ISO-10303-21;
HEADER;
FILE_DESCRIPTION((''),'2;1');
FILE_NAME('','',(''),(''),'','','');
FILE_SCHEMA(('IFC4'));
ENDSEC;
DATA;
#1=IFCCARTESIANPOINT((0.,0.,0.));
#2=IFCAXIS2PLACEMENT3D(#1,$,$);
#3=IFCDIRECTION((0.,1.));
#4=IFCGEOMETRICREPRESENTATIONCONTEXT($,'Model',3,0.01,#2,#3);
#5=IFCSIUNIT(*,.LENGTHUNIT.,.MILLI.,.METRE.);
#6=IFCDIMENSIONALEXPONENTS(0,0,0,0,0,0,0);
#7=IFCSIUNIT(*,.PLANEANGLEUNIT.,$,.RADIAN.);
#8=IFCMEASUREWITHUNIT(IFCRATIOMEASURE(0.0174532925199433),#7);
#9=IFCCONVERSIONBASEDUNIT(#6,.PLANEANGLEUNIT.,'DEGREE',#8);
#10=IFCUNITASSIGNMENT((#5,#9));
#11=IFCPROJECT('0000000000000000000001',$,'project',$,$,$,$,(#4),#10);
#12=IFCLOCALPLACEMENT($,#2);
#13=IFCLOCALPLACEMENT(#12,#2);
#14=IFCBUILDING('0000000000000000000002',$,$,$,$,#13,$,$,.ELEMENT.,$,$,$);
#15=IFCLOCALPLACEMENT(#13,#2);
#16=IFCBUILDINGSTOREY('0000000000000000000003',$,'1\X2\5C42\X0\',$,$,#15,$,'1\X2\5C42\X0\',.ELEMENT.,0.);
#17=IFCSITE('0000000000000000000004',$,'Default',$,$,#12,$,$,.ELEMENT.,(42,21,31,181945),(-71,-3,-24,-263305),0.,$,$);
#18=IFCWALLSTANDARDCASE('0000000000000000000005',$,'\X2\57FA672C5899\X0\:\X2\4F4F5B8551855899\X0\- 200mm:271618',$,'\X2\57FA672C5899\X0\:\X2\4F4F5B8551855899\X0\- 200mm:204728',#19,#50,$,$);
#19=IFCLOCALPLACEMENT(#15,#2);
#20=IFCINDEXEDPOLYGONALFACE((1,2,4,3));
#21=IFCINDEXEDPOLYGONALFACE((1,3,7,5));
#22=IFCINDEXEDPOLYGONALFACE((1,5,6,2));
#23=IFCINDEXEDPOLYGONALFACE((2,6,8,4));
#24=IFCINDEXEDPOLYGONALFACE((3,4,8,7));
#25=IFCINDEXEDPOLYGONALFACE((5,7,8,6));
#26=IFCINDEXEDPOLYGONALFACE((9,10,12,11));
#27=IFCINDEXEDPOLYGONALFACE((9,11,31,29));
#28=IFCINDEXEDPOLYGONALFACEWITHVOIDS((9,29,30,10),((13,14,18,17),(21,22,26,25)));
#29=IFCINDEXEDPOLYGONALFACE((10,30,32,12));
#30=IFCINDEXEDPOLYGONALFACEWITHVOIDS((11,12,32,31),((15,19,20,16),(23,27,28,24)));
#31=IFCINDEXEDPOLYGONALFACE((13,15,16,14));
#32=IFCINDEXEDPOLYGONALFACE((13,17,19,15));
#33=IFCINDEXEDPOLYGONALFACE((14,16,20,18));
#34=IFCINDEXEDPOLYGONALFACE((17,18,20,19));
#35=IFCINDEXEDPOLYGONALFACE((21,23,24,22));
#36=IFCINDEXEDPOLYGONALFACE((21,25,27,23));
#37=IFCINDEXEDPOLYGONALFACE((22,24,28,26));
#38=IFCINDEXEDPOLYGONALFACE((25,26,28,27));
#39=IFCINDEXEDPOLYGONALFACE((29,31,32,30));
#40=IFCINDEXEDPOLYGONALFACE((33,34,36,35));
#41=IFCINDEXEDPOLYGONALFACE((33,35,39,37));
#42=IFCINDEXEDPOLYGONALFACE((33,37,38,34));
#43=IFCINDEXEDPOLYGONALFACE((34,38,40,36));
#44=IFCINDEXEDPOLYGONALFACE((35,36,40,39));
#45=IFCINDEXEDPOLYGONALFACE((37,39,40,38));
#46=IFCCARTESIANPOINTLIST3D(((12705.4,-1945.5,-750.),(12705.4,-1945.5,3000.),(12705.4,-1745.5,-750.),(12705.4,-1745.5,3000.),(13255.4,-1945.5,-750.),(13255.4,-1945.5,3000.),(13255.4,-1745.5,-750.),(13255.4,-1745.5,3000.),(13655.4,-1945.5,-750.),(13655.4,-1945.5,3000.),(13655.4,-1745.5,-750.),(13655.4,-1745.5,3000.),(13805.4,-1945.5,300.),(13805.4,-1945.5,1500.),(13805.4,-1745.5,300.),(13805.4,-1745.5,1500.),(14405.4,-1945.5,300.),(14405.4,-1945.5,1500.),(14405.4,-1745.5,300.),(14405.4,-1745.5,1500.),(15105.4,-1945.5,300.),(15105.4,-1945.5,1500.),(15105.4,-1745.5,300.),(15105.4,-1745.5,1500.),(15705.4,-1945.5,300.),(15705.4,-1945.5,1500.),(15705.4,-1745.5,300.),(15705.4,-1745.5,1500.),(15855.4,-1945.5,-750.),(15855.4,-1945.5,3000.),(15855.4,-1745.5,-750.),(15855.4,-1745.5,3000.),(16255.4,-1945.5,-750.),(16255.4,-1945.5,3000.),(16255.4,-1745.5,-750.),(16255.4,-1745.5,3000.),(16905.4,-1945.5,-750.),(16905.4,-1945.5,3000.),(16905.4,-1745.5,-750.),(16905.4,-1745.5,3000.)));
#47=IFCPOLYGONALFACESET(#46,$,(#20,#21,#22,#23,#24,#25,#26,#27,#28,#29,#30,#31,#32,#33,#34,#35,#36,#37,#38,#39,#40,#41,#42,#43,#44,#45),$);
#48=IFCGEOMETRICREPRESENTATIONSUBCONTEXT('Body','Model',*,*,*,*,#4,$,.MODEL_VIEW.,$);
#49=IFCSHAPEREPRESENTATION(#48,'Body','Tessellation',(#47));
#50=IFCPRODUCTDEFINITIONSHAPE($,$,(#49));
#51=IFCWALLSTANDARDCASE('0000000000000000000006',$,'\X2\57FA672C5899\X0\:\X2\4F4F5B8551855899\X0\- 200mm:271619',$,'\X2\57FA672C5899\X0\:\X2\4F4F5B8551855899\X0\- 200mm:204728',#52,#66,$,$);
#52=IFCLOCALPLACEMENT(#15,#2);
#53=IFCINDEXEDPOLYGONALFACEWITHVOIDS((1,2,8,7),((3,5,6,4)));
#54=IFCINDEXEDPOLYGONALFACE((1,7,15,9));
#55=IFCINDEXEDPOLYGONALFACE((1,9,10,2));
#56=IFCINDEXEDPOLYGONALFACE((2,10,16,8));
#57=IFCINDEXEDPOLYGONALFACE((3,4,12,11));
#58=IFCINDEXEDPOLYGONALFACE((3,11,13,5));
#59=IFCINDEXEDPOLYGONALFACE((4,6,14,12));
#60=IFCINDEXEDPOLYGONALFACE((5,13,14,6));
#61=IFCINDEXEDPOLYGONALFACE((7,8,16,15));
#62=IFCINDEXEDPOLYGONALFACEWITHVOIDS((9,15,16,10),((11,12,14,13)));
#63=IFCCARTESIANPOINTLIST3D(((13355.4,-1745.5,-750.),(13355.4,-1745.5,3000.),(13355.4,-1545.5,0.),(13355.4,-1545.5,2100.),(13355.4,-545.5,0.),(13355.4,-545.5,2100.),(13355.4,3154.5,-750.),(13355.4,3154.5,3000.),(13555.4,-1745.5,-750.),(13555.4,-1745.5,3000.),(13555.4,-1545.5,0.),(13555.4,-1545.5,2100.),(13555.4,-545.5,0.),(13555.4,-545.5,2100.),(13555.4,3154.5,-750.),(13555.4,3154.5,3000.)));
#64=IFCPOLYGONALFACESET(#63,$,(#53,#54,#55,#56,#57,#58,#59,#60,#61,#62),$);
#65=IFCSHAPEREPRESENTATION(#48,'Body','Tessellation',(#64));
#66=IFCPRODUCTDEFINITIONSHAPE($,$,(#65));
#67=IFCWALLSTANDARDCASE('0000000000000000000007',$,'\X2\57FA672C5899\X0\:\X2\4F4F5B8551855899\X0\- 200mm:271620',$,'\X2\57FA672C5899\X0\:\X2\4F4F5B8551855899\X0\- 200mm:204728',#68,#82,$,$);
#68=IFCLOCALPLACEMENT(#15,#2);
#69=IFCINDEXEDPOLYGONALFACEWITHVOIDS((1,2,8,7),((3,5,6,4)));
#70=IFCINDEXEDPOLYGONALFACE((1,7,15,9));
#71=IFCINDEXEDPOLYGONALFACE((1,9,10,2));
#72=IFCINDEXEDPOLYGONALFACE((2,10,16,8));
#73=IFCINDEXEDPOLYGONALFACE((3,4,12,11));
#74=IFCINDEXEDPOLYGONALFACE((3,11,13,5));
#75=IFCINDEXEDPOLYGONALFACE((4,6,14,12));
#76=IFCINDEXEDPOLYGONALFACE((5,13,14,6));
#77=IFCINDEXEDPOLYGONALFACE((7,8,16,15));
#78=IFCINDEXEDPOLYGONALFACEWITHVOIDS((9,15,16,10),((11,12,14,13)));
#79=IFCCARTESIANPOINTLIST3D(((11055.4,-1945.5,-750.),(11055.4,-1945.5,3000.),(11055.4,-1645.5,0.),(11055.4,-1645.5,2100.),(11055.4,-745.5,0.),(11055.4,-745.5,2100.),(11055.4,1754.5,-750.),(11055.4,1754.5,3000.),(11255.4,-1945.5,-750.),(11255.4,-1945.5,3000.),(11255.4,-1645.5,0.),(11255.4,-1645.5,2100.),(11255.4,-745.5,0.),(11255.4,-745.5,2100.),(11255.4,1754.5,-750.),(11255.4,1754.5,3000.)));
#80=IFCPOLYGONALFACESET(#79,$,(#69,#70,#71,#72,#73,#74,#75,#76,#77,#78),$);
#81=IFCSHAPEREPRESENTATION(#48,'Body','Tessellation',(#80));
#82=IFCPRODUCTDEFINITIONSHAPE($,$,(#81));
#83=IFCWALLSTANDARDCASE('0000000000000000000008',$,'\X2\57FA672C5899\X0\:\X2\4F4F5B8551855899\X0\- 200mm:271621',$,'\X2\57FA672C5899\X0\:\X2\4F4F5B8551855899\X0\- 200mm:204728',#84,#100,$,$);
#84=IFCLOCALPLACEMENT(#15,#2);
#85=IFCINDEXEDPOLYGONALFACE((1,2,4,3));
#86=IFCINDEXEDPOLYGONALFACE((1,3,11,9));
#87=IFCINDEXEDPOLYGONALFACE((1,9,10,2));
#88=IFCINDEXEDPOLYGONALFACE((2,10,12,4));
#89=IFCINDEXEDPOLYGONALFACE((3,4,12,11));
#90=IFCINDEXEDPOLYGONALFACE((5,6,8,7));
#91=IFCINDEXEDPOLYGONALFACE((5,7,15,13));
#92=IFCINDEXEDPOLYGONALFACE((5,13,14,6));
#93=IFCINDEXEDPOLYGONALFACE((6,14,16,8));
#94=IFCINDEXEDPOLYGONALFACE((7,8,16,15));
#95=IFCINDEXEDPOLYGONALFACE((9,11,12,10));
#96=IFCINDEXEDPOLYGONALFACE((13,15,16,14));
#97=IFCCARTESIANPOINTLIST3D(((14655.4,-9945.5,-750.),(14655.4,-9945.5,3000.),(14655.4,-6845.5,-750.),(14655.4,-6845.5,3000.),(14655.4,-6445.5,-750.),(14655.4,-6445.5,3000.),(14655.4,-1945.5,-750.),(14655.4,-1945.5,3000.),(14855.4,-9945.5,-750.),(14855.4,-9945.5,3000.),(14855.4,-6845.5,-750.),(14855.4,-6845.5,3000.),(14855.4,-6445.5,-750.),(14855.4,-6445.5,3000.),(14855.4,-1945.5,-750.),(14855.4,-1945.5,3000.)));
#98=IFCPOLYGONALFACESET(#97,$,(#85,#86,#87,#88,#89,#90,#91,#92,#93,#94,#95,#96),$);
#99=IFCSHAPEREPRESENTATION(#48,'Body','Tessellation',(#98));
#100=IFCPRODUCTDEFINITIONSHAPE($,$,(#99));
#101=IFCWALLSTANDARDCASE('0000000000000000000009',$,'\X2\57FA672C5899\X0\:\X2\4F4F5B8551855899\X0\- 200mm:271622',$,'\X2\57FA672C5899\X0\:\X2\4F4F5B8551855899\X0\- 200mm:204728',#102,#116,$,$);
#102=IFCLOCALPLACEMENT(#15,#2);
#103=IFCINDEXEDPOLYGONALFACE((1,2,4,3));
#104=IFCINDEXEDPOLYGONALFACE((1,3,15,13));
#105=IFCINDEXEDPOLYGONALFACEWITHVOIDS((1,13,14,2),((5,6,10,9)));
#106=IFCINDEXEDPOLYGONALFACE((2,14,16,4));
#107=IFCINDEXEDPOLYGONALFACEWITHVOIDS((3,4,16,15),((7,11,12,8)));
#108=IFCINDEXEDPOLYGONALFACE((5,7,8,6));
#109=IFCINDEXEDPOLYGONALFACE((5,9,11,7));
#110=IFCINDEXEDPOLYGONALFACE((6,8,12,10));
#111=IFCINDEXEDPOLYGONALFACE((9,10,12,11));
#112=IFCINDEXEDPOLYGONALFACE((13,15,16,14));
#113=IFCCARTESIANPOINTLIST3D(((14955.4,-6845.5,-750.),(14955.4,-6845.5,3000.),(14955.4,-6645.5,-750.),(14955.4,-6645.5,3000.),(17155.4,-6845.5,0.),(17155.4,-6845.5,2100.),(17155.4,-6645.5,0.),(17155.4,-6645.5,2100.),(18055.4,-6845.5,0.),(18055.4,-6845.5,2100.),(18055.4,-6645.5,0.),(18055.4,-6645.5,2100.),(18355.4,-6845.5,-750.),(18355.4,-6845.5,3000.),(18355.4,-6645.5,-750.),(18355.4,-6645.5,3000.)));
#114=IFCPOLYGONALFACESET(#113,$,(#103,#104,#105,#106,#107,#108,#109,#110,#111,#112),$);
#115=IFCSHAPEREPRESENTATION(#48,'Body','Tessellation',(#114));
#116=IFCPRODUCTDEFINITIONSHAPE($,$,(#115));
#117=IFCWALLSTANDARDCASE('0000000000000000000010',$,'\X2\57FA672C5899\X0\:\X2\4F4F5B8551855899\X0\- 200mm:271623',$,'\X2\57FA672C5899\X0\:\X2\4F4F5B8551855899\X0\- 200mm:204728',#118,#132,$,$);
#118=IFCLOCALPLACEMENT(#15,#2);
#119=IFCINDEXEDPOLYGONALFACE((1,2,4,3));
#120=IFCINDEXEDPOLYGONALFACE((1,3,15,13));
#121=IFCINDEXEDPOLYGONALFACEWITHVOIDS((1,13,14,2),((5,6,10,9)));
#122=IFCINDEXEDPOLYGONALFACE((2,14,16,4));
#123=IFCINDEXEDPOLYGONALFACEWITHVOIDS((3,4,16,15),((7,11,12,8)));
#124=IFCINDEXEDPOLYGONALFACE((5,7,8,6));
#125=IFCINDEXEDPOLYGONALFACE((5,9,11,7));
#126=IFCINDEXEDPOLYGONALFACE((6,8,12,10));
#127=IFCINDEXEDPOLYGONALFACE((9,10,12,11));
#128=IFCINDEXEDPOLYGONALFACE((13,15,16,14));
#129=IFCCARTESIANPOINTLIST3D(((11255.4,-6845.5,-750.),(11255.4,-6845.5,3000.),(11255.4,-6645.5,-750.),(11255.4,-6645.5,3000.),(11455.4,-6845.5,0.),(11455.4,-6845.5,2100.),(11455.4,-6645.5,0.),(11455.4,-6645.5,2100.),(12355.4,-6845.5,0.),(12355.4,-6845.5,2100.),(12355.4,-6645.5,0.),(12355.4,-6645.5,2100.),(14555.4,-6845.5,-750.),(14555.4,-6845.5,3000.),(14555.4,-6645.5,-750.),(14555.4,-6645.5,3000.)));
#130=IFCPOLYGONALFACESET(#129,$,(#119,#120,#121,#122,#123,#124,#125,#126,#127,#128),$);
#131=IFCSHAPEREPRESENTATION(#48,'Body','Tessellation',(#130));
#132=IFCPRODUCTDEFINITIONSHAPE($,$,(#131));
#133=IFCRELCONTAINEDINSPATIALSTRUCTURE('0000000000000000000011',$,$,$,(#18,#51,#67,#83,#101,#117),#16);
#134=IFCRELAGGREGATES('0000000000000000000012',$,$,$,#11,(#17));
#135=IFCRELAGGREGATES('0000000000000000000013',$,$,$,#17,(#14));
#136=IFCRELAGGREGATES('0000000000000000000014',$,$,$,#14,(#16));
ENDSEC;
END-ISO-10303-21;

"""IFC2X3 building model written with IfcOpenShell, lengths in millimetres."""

from ifc_helpers import new_model, entity, si_unit, converted_unit, direction, frame, frame_2d, origin, origin_2d_with_axis, place, context, subcontext, project, spatial, polyline, rectangle, extrude, clip, bounded_halfspace, element, save


model = new_model("IFC2X3")

# Units and contexts
model_context = context("Model", 3, precision=0.01, world=origin(), true_north=direction((0.0, 1.0)))
body_context = subcontext(model_context, "Body", "Model", "MODEL_VIEW")
ifc_project = project(units=[si_unit("LENGTHUNIT", "METRE", prefix="MILLI"), converted_unit("PLANEANGLEUNIT", "DEGREE", entity("IfcRatioMeasure", 0.0174532925199433), si_unit("PLANEANGLEUNIT", "RADIAN"), dimensions=[0, 0, 0, 0, 0, 0, 0])], contexts=[model_context])

# Site, building, storey
site_placement = place(None, origin())
site = spatial("IfcSite", under=ifc_project, at=site_placement, Name="Default", CompositionType="ELEMENT", RefLatitude=(42, 21, 31, 181945), RefLongitude=(-71, -3, -24, -263305), RefElevation=0.0)
building_placement = place(site_placement, origin())
building = spatial("IfcBuilding", under=site, at=building_placement, CompositionType="ELEMENT")
storey_placement = place(building_placement, origin())
storey = spatial("IfcBuildingStorey", under=building, at=storey_placement, Name="1层", LongName="1层", CompositionType="ELEMENT", Elevation=0.0)

# Wall, openings
wall_1_placement = place(storey_placement, frame((16905.4, -1845.5, -750.0), z_axis=(0.0, 0.0, 1.0), x_axis=(-1.0, 0.0, 0.0)))
wall_1 = element("IfcWallStandardCase", 1, at=wall_1_placement, inside=storey, Name="基本墙:住宅内墙- 200mm:271618", ObjectType="基本墙:住宅内墙- 200mm:204728", context=body_context, shape_type="SweptSolid", body=[
    extrude(rectangle(XDim=4200.0, YDim=200.0, at=frame_2d((2100.0, 0.0), x_axis=(-1.0, 0.0))), origin(), (0.0, 0.0, 1.0), 3750.0),
])
opening_1_placement = place(wall_1_placement, frame((1200.0, -100.0, 1050.0)))
element("IfcOpeningElement", 2, at=opening_1_placement, cuts=wall_1, ObjectType="Opening", context=body_context, shape_type="SweptSolid", body=[
    extrude(rectangle(XDim=1200.0, YDim=600.0, at=frame_2d((600.0, 300.0), x_axis=(-1.0, 0.0))), frame((0.0, 0.0, 0.0), z_axis=(0.0, 1.0, 0.0), x_axis=(0.0, 0.0, 1.0)), (0.0, 0.0, 1.0), 200.0),
])
opening_2_placement = place(wall_1_placement, frame((2500.0, -100.0, 1050.0)))
element("IfcOpeningElement", 3, at=opening_2_placement, cuts=wall_1, ObjectType="Opening", context=body_context, shape_type="SweptSolid", body=[
    extrude(rectangle(XDim=1200.0, YDim=600.0, at=frame_2d((600.0, 300.0), x_axis=(-1.0, 0.0))), frame((0.0, 0.0, 0.0), z_axis=(0.0, 1.0, 0.0), x_axis=(0.0, 0.0, 1.0)), (0.0, 0.0, 1.0), 200.0),
])
opening_3_placement = place(storey_placement, frame((16905.4, -1845.5, -750.0), z_axis=(0.0, 0.0, 1.0), x_axis=(-1.0, 0.0, 0.0)))
element("IfcOpeningElement", 4, at=opening_3_placement, cuts=wall_1, ObjectType="Opening", context=body_context, shape_type="SweptSolid", body=[
    extrude(rectangle(XDim=3750.0, YDim=200.0, at=origin_2d_with_axis()), frame((3650.0, 0.0, 1875.0), z_axis=(-1.0, 0.0, 0.0), x_axis=(0.0, 0.0, 1.0)), (0.0, 0.0, 1.0), 400.0),
])
opening_4_placement = place(storey_placement, frame((16905.4, -1845.5, -750.0), z_axis=(0.0, 0.0, 1.0), x_axis=(-1.0, 0.0, 0.0)))
element("IfcOpeningElement", 5, at=opening_4_placement, cuts=wall_1, ObjectType="Opening", context=body_context, shape_type="SweptSolid", body=[
    extrude(rectangle(XDim=3750.0, YDim=200.0, at=origin_2d_with_axis()), frame((1050.0, 0.0, 1875.0), z_axis=(-1.0, 0.0, 0.0), x_axis=(0.0, 0.0, 1.0)), (0.0, 0.0, 1.0), 400.0),
])

# Wall, opening
wall_2_placement = place(storey_placement, frame((13455.4, -1745.5, -750.0), z_axis=(0.0, 0.0, 1.0), x_axis=(0.0, 1.0, 0.0)))
wall_2 = element("IfcWallStandardCase", 6, at=wall_2_placement, inside=storey, Name="基本墙:住宅内墙- 200mm:271619", ObjectType="基本墙:住宅内墙- 200mm:204728", context=body_context, shape_type="SweptSolid", body=[
    extrude(rectangle(XDim=4900.0, YDim=200.0, at=frame_2d((2450.0, 0.0), x_axis=(-1.0, 0.0))), origin(), (0.0, 0.0, 1.0), 3750.0),
])
opening_5_placement = place(wall_2_placement, frame((1200.0, 100.0, 750.0)))
element("IfcOpeningElement", 7, at=opening_5_placement, cuts=wall_2, ObjectType="Opening", context=body_context, shape_type="SweptSolid", body=[
    extrude(rectangle(XDim=2100.0, YDim=1000.0, at=frame_2d((1050.0, 500.0), x_axis=(1.0, 0.0))), frame((0.0, 0.0, 0.0), z_axis=(0.0, -1.0, 0.0), x_axis=(0.0, 0.0, 1.0)), (0.0, 0.0, 1.0), 200.0),
])

# Wall, openings
wall_3_placement = place(storey_placement, frame((11155.4, 1754.5, -750.0), z_axis=(0.0, 0.0, 1.0), x_axis=(0.0, -1.0, 0.0)))
wall_3 = element("IfcWallStandardCase", 8, at=wall_3_placement, inside=storey, Name="基本墙:住宅内墙- 200mm:271620", ObjectType="基本墙:住宅内墙- 200mm:204728", context=body_context, shape_type="SweptSolid", body=[
    extrude(rectangle(XDim=3700.0, YDim=200.0, at=frame_2d((1850.0, 0.0), x_axis=(-1.0, 0.0))), origin(), (0.0, 0.0, 1.0), 3750.0),
])
opening_6_placement = place(wall_3_placement, frame((3400.0, 100.0, 750.0)))
element("IfcOpeningElement", 9, at=opening_6_placement, cuts=wall_3, ObjectType="Opening", context=body_context, shape_type="SweptSolid", body=[
    extrude(rectangle(XDim=2100.0, YDim=900.0, at=frame_2d((1050.0, 450.0), x_axis=(1.0, 0.0))), frame((0.0, 0.0, 0.0), z_axis=(0.0, -1.0, 0.0), x_axis=(0.0, 0.0, 1.0)), (0.0, 0.0, 1.0), 200.0),
])
opening_7_placement = place(wall_3_placement, origin())
element("IfcOpeningElement", 10, at=opening_7_placement, cuts=wall_3, ObjectType="Opening", context=body_context, shape_type="SweptSolid", body=[
    extrude(rectangle(XDim=2100.0, YDim=900.0, at=frame_2d((0.0, 0.0), x_axis=(0.0, 1.0))), frame((2950.0, -1424.0, 4800.0), z_axis=(0.0, 1.0, 0.0), x_axis=(-1.0, 0.0, 0.0)), (0.0, 0.0, 1.0), 3048.0),
])

# Wall, opening
wall_4_placement = place(storey_placement, frame((14755.4, -1945.5, -750.0), z_axis=(0.0, 0.0, 1.0), x_axis=(0.0, -1.0, 0.0)))
wall_4 = element("IfcWallStandardCase", 11, at=wall_4_placement, inside=storey, Name="基本墙:住宅内墙- 200mm:271621", ObjectType="基本墙:住宅内墙- 200mm:204728", context=body_context, shape_type="Clipping", body=[
    clip(extrude(rectangle(XDim=8000.0, YDim=200.0, at=frame_2d((4000.0, 0.0), x_axis=(-1.0, 0.0))), origin(), (0.0, 0.0, 1.0), 3750.0), bounded_halfspace(frame((8000.0, -100.0, 3750.0), z_axis=(1.0, 0.0, 0.0), x_axis=(0.0, 0.0, -1.0)), False, frame((8000.0, -100.0, 3750.0), z_axis=(1.0, 0.0, 0.0), x_axis=(0.0, 0.0, -1.0)), polyline([(0.0, 0.0), (3750.0, 0.0), (3750.0, 200.0), (0.0, 200.0), (0.0, 0.0)]))),
])
opening_8_placement = place(storey_placement, frame((14755.4, -1945.5, -750.0), z_axis=(0.0, 0.0, 1.0), x_axis=(0.0, -1.0, 0.0)))
element("IfcOpeningElement", 12, at=opening_8_placement, cuts=wall_4, ObjectType="Opening", context=body_context, shape_type="SweptSolid", body=[
    extrude(rectangle(XDim=3750.0, YDim=200.0, at=frame_2d((0.0, 0.0), x_axis=(1.0, 0.0))), frame((4900.0, 0.0, 1875.0), z_axis=(-1.0, 0.0, 0.0), x_axis=(0.0, 0.0, 1.0)), (0.0, 0.0, 1.0), 400.0),
])

# Walls, openings
wall_5_placement = place(storey_placement, frame((18355.4, -6745.5, -750.0), z_axis=(0.0, 0.0, 1.0), x_axis=(-1.0, 0.0, 0.0)))
wall_5 = element("IfcWallStandardCase", 13, at=wall_5_placement, inside=storey, Name="基本墙:住宅内墙- 200mm:271622", ObjectType="基本墙:住宅内墙- 200mm:204728", context=body_context, shape_type="Clipping", body=[
    clip(extrude(rectangle(XDim=3400.0, YDim=200.0, at=frame_2d((1700.0, 0.0), x_axis=(-1.0, 0.0))), origin(), (0.0, 0.0, 1.0), 3750.0), bounded_halfspace(frame((3400.0, -100.0, 3750.0), z_axis=(1.0, 0.0, 0.0), x_axis=(0.0, 0.0, -1.0)), False, frame((3400.0, -100.0, 3750.0), z_axis=(1.0, 0.0, 0.0), x_axis=(0.0, 0.0, -1.0)), polyline([(0.0, 0.0), (3750.0, 0.0), (3750.0, 200.0), (0.0, 200.0), (0.0, 0.0)]))),
])
opening_9_placement = place(wall_5_placement, frame((300.0, -100.0, 750.0)))
element("IfcOpeningElement", 14, at=opening_9_placement, cuts=wall_5, ObjectType="Opening", context=body_context, shape_type="SweptSolid", body=[
    extrude(rectangle(XDim=2100.0, YDim=900.0, at=frame_2d((1050.0, 450.0), x_axis=(1.0, 0.0))), frame((0.0, 0.0, 0.0), z_axis=(0.0, 1.0, 0.0), x_axis=(0.0, 0.0, 1.0)), (0.0, 0.0, 1.0), 200.0),
])
opening_10_placement = place(wall_5_placement, origin())
element("IfcOpeningElement", 15, at=opening_10_placement, cuts=wall_5, ObjectType="Opening", context=body_context, shape_type="SweptSolid", body=[
    extrude(rectangle(XDim=2100.0, YDim=900.0, at=frame_2d((0.0, 0.0), x_axis=(1.0, 0.0))), frame((750.0, -1624.0, 4800.0), z_axis=(0.0, 1.0, 0.0), x_axis=(0.0, 0.0, 1.0)), (0.0, 0.0, 1.0), 3048.0),
])
wall_6_placement = place(storey_placement, frame((11255.4, -6745.5, -750.0)))
wall_6 = element("IfcWallStandardCase", 16, at=wall_6_placement, inside=storey, Name="基本墙:住宅内墙- 200mm:271623", ObjectType="基本墙:住宅内墙- 200mm:204728", context=body_context, shape_type="Clipping", body=[
    clip(extrude(rectangle(XDim=3300.0, YDim=200.0, at=frame_2d((1650.0, 0.0), x_axis=(-1.0, 0.0))), origin(), (0.0, 0.0, 1.0), 3750.0), bounded_halfspace(frame((3300.0, -100.0, 3750.0), z_axis=(1.0, 0.0, 0.0), x_axis=(0.0, 0.0, -1.0)), False, frame((3300.0, -100.0, 3750.0), z_axis=(1.0, 0.0, 0.0), x_axis=(0.0, 0.0, -1.0)), polyline([(0.0, 0.0), (3750.0, 0.0), (3750.0, 200.0), (0.0, 200.0), (0.0, 0.0)]))),
])
opening_11_placement = place(wall_6_placement, frame((1100.0, 100.0, 750.0)))
element("IfcOpeningElement", 17, at=opening_11_placement, cuts=wall_6, ObjectType="Opening", context=body_context, shape_type="SweptSolid", body=[
    extrude(rectangle(XDim=2100.0, YDim=900.0, at=frame_2d((1050.0, 450.0), x_axis=(1.0, 0.0))), frame((0.0, 0.0, 0.0), z_axis=(0.0, -1.0, 0.0), x_axis=(0.0, 0.0, 1.0)), (0.0, 0.0, 1.0), 200.0),
])
opening_12_placement = place(wall_6_placement, origin())
element("IfcOpeningElement", 18, at=opening_12_placement, cuts=wall_6, ObjectType="Opening", context=body_context, shape_type="SweptSolid", body=[
    extrude(rectangle(XDim=2100.0, YDim=900.0, at=frame_2d((0.0, 0.0), x_axis=(1.0, 0.0))), frame((650.0, -1424.0, 4800.0), z_axis=(0.0, 1.0, 0.0), x_axis=(0.0, 0.0, 1.0)), (0.0, 0.0, 1.0), 3048.0),
])

save(model, "model.ifc")
